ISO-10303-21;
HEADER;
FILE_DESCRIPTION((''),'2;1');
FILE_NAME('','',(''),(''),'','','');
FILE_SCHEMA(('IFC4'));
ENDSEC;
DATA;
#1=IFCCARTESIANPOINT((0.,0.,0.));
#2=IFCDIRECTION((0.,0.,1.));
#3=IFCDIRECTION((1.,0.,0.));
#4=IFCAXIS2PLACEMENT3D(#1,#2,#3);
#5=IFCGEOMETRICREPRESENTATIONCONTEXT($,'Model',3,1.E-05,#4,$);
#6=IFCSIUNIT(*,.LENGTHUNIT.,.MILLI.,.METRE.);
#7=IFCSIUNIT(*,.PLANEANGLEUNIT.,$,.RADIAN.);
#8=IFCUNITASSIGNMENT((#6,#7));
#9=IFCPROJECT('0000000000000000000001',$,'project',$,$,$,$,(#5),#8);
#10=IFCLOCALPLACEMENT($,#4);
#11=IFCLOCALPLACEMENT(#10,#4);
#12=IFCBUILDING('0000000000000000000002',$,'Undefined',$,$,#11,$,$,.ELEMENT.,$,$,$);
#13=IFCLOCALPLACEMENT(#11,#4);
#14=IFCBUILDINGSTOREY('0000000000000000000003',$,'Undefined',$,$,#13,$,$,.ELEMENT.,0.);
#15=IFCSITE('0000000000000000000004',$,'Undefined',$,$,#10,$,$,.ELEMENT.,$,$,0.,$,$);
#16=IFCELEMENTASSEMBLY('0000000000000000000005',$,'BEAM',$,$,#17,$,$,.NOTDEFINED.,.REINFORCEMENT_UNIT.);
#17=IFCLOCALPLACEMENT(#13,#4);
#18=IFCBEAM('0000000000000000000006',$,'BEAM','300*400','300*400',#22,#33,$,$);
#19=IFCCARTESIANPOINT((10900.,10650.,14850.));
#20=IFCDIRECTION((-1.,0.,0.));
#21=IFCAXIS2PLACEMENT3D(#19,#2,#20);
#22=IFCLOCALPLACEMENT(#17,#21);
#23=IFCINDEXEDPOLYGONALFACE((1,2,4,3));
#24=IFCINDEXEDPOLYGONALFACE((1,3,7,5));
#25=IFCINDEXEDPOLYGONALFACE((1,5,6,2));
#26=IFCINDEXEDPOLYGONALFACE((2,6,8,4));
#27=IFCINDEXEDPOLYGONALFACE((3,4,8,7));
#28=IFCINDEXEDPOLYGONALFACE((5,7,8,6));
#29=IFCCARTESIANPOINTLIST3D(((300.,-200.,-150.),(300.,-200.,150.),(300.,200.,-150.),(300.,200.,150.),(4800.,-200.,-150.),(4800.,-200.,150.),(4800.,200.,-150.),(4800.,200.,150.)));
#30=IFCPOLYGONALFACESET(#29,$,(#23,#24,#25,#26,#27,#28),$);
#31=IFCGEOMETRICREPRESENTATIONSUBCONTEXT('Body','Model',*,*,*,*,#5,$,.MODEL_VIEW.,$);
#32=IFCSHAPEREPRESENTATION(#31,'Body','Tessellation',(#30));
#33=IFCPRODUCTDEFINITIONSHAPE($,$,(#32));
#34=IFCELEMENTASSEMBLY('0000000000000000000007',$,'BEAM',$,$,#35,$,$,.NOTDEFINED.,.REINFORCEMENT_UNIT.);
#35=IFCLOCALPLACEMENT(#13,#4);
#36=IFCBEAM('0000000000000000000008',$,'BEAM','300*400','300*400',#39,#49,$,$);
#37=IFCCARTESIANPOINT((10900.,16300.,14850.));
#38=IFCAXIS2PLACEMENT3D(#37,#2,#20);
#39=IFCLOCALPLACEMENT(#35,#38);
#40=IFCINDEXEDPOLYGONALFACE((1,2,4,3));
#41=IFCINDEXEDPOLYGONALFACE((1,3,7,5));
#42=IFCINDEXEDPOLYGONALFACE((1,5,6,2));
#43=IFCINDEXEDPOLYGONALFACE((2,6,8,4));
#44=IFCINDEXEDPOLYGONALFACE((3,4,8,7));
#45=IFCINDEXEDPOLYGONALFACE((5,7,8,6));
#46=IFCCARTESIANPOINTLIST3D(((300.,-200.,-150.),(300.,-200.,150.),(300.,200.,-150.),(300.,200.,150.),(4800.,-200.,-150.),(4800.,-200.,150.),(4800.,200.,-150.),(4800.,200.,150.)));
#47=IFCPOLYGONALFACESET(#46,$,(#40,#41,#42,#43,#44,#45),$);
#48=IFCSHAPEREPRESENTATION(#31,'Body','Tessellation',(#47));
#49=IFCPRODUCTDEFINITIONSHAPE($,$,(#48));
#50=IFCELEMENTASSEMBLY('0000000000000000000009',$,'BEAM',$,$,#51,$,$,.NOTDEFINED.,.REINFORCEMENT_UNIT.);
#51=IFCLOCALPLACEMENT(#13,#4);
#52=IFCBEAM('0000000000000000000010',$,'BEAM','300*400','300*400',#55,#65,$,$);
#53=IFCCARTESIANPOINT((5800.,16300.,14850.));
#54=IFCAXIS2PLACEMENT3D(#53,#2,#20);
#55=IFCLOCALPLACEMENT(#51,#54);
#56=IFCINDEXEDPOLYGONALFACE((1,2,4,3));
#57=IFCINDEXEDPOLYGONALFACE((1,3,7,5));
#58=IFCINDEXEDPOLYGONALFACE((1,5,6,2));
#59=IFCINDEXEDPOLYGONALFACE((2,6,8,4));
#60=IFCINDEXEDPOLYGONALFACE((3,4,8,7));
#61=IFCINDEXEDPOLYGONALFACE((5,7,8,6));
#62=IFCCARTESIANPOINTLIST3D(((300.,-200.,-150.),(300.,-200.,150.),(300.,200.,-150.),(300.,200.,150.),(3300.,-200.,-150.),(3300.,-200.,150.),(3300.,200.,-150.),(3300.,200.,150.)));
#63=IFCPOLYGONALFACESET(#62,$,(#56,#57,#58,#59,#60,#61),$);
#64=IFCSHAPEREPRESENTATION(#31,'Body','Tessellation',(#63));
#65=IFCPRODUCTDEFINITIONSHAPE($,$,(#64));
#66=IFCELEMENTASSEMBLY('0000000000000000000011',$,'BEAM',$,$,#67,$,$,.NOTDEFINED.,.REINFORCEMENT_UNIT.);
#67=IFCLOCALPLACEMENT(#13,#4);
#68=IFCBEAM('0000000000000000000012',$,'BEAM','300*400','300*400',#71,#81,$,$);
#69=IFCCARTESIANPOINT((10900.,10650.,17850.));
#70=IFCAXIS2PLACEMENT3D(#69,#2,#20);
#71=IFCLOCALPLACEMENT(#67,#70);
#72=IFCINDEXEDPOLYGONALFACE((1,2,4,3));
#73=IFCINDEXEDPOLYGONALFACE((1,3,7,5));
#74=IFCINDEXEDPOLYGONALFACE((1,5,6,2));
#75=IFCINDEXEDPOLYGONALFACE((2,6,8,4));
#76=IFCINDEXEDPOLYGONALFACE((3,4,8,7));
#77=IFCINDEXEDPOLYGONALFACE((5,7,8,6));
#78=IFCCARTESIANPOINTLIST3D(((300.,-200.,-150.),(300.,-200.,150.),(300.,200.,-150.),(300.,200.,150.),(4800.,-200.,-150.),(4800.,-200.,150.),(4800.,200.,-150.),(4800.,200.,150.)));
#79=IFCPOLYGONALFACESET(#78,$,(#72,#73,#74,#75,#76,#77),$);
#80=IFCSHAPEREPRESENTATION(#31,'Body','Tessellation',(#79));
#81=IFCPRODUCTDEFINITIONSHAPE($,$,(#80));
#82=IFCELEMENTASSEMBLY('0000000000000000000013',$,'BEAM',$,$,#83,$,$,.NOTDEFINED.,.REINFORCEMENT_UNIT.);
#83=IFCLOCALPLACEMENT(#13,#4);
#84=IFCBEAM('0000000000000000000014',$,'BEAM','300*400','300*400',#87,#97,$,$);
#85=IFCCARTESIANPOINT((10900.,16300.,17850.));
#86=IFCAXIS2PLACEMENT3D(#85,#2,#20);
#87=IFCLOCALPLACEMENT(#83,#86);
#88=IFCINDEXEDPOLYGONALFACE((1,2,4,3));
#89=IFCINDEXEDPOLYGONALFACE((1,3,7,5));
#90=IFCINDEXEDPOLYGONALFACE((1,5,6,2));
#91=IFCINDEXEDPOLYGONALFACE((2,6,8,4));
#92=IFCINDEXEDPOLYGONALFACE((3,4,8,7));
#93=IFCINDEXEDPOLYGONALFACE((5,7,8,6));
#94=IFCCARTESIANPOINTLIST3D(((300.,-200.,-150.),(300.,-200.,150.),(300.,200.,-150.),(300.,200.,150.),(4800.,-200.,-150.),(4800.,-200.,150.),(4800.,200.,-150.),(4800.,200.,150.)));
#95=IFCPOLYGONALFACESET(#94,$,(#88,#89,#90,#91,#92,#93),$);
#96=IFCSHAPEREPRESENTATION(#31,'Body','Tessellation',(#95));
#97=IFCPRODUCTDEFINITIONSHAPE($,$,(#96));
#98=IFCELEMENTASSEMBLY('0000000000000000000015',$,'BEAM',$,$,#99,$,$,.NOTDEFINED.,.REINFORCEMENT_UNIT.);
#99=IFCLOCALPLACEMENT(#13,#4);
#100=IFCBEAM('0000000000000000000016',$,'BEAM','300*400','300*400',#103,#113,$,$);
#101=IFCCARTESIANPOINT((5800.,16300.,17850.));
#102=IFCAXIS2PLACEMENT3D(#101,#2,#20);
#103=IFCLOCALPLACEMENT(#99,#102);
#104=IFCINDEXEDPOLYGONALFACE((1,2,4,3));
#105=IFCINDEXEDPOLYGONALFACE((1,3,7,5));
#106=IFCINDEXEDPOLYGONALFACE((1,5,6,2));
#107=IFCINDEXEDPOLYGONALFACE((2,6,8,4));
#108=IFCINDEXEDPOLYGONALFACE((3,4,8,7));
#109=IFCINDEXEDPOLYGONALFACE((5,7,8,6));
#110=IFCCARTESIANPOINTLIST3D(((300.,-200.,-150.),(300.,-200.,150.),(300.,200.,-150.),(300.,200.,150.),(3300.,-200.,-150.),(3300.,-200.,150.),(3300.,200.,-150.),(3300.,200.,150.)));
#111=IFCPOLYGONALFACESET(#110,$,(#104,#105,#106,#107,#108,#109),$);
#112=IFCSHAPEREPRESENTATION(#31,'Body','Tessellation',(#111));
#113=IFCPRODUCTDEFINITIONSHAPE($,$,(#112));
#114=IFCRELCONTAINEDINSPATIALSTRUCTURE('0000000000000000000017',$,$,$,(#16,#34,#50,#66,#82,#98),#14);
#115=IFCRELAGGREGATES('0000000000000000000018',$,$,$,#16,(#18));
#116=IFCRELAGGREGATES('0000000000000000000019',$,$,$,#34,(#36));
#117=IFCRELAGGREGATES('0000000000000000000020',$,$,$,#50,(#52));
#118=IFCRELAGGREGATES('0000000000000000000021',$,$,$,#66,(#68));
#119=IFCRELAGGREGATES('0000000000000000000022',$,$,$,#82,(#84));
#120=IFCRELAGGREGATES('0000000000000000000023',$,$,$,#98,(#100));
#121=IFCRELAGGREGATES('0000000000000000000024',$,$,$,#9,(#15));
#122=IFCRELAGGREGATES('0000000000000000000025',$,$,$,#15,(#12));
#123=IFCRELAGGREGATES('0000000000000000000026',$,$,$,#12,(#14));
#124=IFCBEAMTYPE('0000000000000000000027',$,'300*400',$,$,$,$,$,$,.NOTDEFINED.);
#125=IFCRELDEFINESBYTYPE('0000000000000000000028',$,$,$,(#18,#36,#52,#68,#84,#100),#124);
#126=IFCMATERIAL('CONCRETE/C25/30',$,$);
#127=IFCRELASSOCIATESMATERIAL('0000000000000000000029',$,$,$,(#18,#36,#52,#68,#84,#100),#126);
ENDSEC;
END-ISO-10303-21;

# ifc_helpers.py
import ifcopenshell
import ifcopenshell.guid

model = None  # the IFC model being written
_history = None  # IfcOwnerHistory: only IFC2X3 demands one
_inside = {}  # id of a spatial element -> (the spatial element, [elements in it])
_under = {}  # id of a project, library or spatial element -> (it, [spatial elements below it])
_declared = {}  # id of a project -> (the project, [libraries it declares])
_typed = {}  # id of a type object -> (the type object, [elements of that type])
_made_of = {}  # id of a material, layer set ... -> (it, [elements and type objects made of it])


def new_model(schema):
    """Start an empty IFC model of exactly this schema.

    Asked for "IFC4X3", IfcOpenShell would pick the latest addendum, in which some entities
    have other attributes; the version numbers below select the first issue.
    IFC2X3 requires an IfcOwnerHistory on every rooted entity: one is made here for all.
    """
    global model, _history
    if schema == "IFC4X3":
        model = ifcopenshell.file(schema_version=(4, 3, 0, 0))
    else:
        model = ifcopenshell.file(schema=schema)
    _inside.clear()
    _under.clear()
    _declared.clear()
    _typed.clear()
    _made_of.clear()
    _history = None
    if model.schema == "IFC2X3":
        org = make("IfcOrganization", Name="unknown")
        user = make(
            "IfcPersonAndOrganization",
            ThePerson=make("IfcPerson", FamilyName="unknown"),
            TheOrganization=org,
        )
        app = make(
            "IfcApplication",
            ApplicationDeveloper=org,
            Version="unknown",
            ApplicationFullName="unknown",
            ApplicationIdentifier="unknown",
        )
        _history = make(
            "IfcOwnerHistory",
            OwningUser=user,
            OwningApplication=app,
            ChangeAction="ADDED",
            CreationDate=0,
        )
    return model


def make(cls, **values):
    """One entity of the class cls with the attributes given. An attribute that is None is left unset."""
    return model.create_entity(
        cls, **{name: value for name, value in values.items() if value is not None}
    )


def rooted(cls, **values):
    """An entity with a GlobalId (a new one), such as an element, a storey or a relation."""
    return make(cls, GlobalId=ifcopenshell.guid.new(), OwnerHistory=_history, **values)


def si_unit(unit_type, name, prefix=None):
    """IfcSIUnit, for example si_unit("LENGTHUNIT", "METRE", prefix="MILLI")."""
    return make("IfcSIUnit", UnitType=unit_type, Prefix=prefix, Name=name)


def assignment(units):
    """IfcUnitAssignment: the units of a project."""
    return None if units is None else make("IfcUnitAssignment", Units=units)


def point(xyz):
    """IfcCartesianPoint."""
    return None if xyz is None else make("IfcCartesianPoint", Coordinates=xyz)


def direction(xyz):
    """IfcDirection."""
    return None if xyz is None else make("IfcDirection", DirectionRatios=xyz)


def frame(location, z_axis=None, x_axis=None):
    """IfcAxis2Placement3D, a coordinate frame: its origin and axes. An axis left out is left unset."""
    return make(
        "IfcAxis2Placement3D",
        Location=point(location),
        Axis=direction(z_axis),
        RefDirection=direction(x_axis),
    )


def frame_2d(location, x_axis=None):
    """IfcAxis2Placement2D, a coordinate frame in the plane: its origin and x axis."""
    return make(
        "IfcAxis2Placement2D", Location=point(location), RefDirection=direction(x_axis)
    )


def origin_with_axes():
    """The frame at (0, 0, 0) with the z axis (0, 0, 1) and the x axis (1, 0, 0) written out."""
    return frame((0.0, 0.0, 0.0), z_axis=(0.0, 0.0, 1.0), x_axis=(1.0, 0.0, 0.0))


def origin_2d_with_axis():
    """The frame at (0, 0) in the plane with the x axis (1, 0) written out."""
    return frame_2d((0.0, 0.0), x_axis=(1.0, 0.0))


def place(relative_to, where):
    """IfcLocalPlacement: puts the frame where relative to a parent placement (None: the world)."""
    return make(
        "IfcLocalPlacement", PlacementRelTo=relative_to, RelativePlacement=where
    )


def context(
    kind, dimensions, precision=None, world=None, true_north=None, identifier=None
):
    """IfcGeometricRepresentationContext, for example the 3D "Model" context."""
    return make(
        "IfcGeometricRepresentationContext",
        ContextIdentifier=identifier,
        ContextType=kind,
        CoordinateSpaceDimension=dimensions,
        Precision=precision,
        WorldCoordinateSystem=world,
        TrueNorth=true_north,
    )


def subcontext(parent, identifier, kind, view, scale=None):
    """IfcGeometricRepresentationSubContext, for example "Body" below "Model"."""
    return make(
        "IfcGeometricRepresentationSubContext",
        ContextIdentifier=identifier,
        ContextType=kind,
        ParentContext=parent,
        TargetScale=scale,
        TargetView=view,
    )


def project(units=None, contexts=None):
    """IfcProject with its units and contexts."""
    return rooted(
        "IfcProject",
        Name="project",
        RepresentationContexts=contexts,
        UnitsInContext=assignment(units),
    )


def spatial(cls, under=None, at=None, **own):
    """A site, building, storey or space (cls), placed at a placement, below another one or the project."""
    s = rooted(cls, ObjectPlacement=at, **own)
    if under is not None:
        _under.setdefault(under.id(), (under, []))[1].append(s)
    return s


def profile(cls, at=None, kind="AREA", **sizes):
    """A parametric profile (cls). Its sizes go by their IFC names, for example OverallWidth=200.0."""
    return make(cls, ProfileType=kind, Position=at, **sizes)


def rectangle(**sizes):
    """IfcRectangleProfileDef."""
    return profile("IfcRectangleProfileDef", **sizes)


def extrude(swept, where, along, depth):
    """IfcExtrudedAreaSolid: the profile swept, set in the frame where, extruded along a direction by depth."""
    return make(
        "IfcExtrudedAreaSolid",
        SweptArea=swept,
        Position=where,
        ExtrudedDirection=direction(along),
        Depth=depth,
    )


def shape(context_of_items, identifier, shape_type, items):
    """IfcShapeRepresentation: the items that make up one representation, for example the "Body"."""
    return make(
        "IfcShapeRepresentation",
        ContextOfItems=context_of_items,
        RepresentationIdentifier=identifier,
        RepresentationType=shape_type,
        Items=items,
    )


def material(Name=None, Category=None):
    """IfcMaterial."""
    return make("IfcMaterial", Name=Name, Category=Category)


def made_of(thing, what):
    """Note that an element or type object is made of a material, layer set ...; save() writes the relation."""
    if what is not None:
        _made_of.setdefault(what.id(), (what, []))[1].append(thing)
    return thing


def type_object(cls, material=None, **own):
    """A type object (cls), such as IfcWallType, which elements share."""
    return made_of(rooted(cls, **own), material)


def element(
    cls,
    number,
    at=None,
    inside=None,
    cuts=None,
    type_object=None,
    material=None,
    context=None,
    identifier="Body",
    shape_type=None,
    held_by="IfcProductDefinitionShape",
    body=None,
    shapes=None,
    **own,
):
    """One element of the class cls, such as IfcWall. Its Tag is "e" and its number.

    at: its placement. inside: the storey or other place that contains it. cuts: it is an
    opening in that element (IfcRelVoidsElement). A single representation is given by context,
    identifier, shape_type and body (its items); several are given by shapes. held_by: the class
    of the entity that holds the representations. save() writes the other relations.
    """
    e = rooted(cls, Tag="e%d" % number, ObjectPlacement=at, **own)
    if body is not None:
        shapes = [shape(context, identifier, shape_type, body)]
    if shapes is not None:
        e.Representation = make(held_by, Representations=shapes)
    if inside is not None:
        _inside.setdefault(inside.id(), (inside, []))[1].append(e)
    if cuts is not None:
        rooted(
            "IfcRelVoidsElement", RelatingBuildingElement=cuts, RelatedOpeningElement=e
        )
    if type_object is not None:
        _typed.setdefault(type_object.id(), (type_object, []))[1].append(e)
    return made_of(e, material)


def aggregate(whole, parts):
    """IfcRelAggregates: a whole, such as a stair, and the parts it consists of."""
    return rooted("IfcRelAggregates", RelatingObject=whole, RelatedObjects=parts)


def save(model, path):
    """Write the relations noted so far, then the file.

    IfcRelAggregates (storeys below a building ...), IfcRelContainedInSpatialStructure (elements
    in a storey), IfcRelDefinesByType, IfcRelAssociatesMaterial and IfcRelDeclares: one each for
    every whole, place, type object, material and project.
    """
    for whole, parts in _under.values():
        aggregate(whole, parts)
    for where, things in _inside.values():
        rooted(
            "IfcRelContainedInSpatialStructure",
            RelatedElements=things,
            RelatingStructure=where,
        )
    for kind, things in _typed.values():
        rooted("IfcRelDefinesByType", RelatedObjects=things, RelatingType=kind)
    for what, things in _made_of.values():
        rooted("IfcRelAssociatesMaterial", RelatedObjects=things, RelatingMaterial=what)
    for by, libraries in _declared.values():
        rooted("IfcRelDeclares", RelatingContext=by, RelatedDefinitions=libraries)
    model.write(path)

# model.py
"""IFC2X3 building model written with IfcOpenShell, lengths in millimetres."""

from ifc_helpers import new_model, si_unit, frame, origin_with_axes, origin_2d_with_axis, place, context, subcontext, project, spatial, rectangle, extrude, material, type_object, element, aggregate, save


model = new_model("IFC2X3")

# Units and contexts
model_context = context("Model", 3, precision=1e-05, world=origin_with_axes())
body_context = subcontext(model_context, "Body", "Model", "MODEL_VIEW")
ifc_project = project(units=[si_unit("LENGTHUNIT", "METRE", prefix="MILLI"), si_unit("PLANEANGLEUNIT", "RADIAN")], contexts=[model_context])

# Site, building, storey
site_placement = place(None, origin_with_axes())
site = spatial("IfcSite", under=ifc_project, at=site_placement, Name="Undefined", CompositionType="ELEMENT", RefElevation=0.0)
building_placement = place(site_placement, origin_with_axes())
building = spatial("IfcBuilding", under=site, at=building_placement, Name="Undefined", CompositionType="ELEMENT")
storey_placement = place(building_placement, origin_with_axes())
storey = spatial("IfcBuildingStorey", under=building, at=storey_placement, Name="Undefined", CompositionType="ELEMENT", Elevation=0.0)

# Shared definitions
ifc_material = material(Name="CONCRETE/C25/30")

# Element assemblies, beams
beam_type_1 = type_object("IfcBeamType", Name="300*400", PredefinedType="NOTDEFINED")
assembly_1_placement = place(storey_placement, origin_with_axes())
assembly_1 = element("IfcElementAssembly", 1, at=assembly_1_placement, inside=storey, Name="BEAM", AssemblyPlace="NOTDEFINED", PredefinedType="REINFORCEMENT_UNIT")
beam_1_placement = place(assembly_1_placement, frame((10900.0, 10650.0, 14850.0), z_axis=(0.0, 0.0, 1.0), x_axis=(-1.0, 0.0, 0.0)))
beam_1 = element("IfcBeam", 2, at=beam_1_placement, type_object=beam_type_1, material=ifc_material, Name="BEAM", Description="300*400", ObjectType="300*400", context=body_context, shape_type="SweptSolid", body=[
    extrude(rectangle(XDim=400.0, YDim=300.0, at=origin_2d_with_axis()), frame((4800.0, 0.0, 0.0), z_axis=(-1.0, 0.0, 0.0), x_axis=(0.0, -1.0, 0.0)), (0.0, 0.0, 1.0), 4500.0),
])
aggregate(assembly_1, [beam_1])
assembly_2_placement = place(storey_placement, origin_with_axes())
assembly_2 = element("IfcElementAssembly", 3, at=assembly_2_placement, inside=storey, Name="BEAM", AssemblyPlace="NOTDEFINED", PredefinedType="REINFORCEMENT_UNIT")
beam_2_placement = place(assembly_2_placement, frame((10900.0, 16300.0, 14850.0), z_axis=(0.0, 0.0, 1.0), x_axis=(-1.0, 0.0, 0.0)))
beam_2 = element("IfcBeam", 4, at=beam_2_placement, type_object=beam_type_1, material=ifc_material, Name="BEAM", Description="300*400", ObjectType="300*400", context=body_context, shape_type="SweptSolid", body=[
    extrude(rectangle(XDim=400.0, YDim=300.0, at=origin_2d_with_axis()), frame((4800.0, 0.0, 0.0), z_axis=(-1.0, 0.0, 0.0), x_axis=(0.0, -1.0, 0.0)), (0.0, 0.0, 1.0), 4500.0),
])
aggregate(assembly_2, [beam_2])
assembly_3_placement = place(storey_placement, origin_with_axes())
assembly_3 = element("IfcElementAssembly", 5, at=assembly_3_placement, inside=storey, Name="BEAM", AssemblyPlace="NOTDEFINED", PredefinedType="REINFORCEMENT_UNIT")
beam_3_placement = place(assembly_3_placement, frame((5800.0, 16300.0, 14850.0), z_axis=(0.0, 0.0, 1.0), x_axis=(-1.0, 0.0, 0.0)))
beam_3 = element("IfcBeam", 6, at=beam_3_placement, type_object=beam_type_1, material=ifc_material, Name="BEAM", Description="300*400", ObjectType="300*400", context=body_context, shape_type="SweptSolid", body=[
    extrude(rectangle(XDim=400.0, YDim=300.0, at=origin_2d_with_axis()), frame((3300.0, 0.0, 0.0), z_axis=(-1.0, 0.0, 0.0), x_axis=(0.0, -1.0, 0.0)), (0.0, 0.0, 1.0), 3000.0),
])
aggregate(assembly_3, [beam_3])
assembly_4_placement = place(storey_placement, origin_with_axes())
assembly_4 = element("IfcElementAssembly", 7, at=assembly_4_placement, inside=storey, Name="BEAM", AssemblyPlace="NOTDEFINED", PredefinedType="REINFORCEMENT_UNIT")
beam_4_placement = place(assembly_4_placement, frame((10900.0, 10650.0, 17850.0), z_axis=(0.0, 0.0, 1.0), x_axis=(-1.0, 0.0, 0.0)))
beam_4 = element("IfcBeam", 8, at=beam_4_placement, type_object=beam_type_1, material=ifc_material, Name="BEAM", Description="300*400", ObjectType="300*400", context=body_context, shape_type="SweptSolid", body=[
    extrude(rectangle(XDim=400.0, YDim=300.0, at=origin_2d_with_axis()), frame((4800.0, 0.0, 0.0), z_axis=(-1.0, 0.0, 0.0), x_axis=(0.0, -1.0, 0.0)), (0.0, 0.0, 1.0), 4500.0),
])
aggregate(assembly_4, [beam_4])
assembly_5_placement = place(storey_placement, origin_with_axes())
assembly_5 = element("IfcElementAssembly", 9, at=assembly_5_placement, inside=storey, Name="BEAM", AssemblyPlace="NOTDEFINED", PredefinedType="REINFORCEMENT_UNIT")
beam_5_placement = place(assembly_5_placement, frame((10900.0, 16300.0, 17850.0), z_axis=(0.0, 0.0, 1.0), x_axis=(-1.0, 0.0, 0.0)))
beam_5 = element("IfcBeam", 10, at=beam_5_placement, type_object=beam_type_1, material=ifc_material, Name="BEAM", Description="300*400", ObjectType="300*400", context=body_context, shape_type="SweptSolid", body=[
    extrude(rectangle(XDim=400.0, YDim=300.0, at=origin_2d_with_axis()), frame((4800.0, 0.0, 0.0), z_axis=(-1.0, 0.0, 0.0), x_axis=(0.0, -1.0, 0.0)), (0.0, 0.0, 1.0), 4500.0),
])
aggregate(assembly_5, [beam_5])
assembly_6_placement = place(storey_placement, origin_with_axes())
assembly_6 = element("IfcElementAssembly", 11, at=assembly_6_placement, inside=storey, Name="BEAM", AssemblyPlace="NOTDEFINED", PredefinedType="REINFORCEMENT_UNIT")
beam_6_placement = place(assembly_6_placement, frame((5800.0, 16300.0, 17850.0), z_axis=(0.0, 0.0, 1.0), x_axis=(-1.0, 0.0, 0.0)))
beam_6 = element("IfcBeam", 12, at=beam_6_placement, type_object=beam_type_1, material=ifc_material, Name="BEAM", Description="300*400", ObjectType="300*400", context=body_context, shape_type="SweptSolid", body=[
    extrude(rectangle(XDim=400.0, YDim=300.0, at=origin_2d_with_axis()), frame((3300.0, 0.0, 0.0), z_axis=(-1.0, 0.0, 0.0), x_axis=(0.0, -1.0, 0.0)), (0.0, 0.0, 1.0), 3000.0),
])
aggregate(assembly_6, [beam_6])

save(model, "model.ifc")
